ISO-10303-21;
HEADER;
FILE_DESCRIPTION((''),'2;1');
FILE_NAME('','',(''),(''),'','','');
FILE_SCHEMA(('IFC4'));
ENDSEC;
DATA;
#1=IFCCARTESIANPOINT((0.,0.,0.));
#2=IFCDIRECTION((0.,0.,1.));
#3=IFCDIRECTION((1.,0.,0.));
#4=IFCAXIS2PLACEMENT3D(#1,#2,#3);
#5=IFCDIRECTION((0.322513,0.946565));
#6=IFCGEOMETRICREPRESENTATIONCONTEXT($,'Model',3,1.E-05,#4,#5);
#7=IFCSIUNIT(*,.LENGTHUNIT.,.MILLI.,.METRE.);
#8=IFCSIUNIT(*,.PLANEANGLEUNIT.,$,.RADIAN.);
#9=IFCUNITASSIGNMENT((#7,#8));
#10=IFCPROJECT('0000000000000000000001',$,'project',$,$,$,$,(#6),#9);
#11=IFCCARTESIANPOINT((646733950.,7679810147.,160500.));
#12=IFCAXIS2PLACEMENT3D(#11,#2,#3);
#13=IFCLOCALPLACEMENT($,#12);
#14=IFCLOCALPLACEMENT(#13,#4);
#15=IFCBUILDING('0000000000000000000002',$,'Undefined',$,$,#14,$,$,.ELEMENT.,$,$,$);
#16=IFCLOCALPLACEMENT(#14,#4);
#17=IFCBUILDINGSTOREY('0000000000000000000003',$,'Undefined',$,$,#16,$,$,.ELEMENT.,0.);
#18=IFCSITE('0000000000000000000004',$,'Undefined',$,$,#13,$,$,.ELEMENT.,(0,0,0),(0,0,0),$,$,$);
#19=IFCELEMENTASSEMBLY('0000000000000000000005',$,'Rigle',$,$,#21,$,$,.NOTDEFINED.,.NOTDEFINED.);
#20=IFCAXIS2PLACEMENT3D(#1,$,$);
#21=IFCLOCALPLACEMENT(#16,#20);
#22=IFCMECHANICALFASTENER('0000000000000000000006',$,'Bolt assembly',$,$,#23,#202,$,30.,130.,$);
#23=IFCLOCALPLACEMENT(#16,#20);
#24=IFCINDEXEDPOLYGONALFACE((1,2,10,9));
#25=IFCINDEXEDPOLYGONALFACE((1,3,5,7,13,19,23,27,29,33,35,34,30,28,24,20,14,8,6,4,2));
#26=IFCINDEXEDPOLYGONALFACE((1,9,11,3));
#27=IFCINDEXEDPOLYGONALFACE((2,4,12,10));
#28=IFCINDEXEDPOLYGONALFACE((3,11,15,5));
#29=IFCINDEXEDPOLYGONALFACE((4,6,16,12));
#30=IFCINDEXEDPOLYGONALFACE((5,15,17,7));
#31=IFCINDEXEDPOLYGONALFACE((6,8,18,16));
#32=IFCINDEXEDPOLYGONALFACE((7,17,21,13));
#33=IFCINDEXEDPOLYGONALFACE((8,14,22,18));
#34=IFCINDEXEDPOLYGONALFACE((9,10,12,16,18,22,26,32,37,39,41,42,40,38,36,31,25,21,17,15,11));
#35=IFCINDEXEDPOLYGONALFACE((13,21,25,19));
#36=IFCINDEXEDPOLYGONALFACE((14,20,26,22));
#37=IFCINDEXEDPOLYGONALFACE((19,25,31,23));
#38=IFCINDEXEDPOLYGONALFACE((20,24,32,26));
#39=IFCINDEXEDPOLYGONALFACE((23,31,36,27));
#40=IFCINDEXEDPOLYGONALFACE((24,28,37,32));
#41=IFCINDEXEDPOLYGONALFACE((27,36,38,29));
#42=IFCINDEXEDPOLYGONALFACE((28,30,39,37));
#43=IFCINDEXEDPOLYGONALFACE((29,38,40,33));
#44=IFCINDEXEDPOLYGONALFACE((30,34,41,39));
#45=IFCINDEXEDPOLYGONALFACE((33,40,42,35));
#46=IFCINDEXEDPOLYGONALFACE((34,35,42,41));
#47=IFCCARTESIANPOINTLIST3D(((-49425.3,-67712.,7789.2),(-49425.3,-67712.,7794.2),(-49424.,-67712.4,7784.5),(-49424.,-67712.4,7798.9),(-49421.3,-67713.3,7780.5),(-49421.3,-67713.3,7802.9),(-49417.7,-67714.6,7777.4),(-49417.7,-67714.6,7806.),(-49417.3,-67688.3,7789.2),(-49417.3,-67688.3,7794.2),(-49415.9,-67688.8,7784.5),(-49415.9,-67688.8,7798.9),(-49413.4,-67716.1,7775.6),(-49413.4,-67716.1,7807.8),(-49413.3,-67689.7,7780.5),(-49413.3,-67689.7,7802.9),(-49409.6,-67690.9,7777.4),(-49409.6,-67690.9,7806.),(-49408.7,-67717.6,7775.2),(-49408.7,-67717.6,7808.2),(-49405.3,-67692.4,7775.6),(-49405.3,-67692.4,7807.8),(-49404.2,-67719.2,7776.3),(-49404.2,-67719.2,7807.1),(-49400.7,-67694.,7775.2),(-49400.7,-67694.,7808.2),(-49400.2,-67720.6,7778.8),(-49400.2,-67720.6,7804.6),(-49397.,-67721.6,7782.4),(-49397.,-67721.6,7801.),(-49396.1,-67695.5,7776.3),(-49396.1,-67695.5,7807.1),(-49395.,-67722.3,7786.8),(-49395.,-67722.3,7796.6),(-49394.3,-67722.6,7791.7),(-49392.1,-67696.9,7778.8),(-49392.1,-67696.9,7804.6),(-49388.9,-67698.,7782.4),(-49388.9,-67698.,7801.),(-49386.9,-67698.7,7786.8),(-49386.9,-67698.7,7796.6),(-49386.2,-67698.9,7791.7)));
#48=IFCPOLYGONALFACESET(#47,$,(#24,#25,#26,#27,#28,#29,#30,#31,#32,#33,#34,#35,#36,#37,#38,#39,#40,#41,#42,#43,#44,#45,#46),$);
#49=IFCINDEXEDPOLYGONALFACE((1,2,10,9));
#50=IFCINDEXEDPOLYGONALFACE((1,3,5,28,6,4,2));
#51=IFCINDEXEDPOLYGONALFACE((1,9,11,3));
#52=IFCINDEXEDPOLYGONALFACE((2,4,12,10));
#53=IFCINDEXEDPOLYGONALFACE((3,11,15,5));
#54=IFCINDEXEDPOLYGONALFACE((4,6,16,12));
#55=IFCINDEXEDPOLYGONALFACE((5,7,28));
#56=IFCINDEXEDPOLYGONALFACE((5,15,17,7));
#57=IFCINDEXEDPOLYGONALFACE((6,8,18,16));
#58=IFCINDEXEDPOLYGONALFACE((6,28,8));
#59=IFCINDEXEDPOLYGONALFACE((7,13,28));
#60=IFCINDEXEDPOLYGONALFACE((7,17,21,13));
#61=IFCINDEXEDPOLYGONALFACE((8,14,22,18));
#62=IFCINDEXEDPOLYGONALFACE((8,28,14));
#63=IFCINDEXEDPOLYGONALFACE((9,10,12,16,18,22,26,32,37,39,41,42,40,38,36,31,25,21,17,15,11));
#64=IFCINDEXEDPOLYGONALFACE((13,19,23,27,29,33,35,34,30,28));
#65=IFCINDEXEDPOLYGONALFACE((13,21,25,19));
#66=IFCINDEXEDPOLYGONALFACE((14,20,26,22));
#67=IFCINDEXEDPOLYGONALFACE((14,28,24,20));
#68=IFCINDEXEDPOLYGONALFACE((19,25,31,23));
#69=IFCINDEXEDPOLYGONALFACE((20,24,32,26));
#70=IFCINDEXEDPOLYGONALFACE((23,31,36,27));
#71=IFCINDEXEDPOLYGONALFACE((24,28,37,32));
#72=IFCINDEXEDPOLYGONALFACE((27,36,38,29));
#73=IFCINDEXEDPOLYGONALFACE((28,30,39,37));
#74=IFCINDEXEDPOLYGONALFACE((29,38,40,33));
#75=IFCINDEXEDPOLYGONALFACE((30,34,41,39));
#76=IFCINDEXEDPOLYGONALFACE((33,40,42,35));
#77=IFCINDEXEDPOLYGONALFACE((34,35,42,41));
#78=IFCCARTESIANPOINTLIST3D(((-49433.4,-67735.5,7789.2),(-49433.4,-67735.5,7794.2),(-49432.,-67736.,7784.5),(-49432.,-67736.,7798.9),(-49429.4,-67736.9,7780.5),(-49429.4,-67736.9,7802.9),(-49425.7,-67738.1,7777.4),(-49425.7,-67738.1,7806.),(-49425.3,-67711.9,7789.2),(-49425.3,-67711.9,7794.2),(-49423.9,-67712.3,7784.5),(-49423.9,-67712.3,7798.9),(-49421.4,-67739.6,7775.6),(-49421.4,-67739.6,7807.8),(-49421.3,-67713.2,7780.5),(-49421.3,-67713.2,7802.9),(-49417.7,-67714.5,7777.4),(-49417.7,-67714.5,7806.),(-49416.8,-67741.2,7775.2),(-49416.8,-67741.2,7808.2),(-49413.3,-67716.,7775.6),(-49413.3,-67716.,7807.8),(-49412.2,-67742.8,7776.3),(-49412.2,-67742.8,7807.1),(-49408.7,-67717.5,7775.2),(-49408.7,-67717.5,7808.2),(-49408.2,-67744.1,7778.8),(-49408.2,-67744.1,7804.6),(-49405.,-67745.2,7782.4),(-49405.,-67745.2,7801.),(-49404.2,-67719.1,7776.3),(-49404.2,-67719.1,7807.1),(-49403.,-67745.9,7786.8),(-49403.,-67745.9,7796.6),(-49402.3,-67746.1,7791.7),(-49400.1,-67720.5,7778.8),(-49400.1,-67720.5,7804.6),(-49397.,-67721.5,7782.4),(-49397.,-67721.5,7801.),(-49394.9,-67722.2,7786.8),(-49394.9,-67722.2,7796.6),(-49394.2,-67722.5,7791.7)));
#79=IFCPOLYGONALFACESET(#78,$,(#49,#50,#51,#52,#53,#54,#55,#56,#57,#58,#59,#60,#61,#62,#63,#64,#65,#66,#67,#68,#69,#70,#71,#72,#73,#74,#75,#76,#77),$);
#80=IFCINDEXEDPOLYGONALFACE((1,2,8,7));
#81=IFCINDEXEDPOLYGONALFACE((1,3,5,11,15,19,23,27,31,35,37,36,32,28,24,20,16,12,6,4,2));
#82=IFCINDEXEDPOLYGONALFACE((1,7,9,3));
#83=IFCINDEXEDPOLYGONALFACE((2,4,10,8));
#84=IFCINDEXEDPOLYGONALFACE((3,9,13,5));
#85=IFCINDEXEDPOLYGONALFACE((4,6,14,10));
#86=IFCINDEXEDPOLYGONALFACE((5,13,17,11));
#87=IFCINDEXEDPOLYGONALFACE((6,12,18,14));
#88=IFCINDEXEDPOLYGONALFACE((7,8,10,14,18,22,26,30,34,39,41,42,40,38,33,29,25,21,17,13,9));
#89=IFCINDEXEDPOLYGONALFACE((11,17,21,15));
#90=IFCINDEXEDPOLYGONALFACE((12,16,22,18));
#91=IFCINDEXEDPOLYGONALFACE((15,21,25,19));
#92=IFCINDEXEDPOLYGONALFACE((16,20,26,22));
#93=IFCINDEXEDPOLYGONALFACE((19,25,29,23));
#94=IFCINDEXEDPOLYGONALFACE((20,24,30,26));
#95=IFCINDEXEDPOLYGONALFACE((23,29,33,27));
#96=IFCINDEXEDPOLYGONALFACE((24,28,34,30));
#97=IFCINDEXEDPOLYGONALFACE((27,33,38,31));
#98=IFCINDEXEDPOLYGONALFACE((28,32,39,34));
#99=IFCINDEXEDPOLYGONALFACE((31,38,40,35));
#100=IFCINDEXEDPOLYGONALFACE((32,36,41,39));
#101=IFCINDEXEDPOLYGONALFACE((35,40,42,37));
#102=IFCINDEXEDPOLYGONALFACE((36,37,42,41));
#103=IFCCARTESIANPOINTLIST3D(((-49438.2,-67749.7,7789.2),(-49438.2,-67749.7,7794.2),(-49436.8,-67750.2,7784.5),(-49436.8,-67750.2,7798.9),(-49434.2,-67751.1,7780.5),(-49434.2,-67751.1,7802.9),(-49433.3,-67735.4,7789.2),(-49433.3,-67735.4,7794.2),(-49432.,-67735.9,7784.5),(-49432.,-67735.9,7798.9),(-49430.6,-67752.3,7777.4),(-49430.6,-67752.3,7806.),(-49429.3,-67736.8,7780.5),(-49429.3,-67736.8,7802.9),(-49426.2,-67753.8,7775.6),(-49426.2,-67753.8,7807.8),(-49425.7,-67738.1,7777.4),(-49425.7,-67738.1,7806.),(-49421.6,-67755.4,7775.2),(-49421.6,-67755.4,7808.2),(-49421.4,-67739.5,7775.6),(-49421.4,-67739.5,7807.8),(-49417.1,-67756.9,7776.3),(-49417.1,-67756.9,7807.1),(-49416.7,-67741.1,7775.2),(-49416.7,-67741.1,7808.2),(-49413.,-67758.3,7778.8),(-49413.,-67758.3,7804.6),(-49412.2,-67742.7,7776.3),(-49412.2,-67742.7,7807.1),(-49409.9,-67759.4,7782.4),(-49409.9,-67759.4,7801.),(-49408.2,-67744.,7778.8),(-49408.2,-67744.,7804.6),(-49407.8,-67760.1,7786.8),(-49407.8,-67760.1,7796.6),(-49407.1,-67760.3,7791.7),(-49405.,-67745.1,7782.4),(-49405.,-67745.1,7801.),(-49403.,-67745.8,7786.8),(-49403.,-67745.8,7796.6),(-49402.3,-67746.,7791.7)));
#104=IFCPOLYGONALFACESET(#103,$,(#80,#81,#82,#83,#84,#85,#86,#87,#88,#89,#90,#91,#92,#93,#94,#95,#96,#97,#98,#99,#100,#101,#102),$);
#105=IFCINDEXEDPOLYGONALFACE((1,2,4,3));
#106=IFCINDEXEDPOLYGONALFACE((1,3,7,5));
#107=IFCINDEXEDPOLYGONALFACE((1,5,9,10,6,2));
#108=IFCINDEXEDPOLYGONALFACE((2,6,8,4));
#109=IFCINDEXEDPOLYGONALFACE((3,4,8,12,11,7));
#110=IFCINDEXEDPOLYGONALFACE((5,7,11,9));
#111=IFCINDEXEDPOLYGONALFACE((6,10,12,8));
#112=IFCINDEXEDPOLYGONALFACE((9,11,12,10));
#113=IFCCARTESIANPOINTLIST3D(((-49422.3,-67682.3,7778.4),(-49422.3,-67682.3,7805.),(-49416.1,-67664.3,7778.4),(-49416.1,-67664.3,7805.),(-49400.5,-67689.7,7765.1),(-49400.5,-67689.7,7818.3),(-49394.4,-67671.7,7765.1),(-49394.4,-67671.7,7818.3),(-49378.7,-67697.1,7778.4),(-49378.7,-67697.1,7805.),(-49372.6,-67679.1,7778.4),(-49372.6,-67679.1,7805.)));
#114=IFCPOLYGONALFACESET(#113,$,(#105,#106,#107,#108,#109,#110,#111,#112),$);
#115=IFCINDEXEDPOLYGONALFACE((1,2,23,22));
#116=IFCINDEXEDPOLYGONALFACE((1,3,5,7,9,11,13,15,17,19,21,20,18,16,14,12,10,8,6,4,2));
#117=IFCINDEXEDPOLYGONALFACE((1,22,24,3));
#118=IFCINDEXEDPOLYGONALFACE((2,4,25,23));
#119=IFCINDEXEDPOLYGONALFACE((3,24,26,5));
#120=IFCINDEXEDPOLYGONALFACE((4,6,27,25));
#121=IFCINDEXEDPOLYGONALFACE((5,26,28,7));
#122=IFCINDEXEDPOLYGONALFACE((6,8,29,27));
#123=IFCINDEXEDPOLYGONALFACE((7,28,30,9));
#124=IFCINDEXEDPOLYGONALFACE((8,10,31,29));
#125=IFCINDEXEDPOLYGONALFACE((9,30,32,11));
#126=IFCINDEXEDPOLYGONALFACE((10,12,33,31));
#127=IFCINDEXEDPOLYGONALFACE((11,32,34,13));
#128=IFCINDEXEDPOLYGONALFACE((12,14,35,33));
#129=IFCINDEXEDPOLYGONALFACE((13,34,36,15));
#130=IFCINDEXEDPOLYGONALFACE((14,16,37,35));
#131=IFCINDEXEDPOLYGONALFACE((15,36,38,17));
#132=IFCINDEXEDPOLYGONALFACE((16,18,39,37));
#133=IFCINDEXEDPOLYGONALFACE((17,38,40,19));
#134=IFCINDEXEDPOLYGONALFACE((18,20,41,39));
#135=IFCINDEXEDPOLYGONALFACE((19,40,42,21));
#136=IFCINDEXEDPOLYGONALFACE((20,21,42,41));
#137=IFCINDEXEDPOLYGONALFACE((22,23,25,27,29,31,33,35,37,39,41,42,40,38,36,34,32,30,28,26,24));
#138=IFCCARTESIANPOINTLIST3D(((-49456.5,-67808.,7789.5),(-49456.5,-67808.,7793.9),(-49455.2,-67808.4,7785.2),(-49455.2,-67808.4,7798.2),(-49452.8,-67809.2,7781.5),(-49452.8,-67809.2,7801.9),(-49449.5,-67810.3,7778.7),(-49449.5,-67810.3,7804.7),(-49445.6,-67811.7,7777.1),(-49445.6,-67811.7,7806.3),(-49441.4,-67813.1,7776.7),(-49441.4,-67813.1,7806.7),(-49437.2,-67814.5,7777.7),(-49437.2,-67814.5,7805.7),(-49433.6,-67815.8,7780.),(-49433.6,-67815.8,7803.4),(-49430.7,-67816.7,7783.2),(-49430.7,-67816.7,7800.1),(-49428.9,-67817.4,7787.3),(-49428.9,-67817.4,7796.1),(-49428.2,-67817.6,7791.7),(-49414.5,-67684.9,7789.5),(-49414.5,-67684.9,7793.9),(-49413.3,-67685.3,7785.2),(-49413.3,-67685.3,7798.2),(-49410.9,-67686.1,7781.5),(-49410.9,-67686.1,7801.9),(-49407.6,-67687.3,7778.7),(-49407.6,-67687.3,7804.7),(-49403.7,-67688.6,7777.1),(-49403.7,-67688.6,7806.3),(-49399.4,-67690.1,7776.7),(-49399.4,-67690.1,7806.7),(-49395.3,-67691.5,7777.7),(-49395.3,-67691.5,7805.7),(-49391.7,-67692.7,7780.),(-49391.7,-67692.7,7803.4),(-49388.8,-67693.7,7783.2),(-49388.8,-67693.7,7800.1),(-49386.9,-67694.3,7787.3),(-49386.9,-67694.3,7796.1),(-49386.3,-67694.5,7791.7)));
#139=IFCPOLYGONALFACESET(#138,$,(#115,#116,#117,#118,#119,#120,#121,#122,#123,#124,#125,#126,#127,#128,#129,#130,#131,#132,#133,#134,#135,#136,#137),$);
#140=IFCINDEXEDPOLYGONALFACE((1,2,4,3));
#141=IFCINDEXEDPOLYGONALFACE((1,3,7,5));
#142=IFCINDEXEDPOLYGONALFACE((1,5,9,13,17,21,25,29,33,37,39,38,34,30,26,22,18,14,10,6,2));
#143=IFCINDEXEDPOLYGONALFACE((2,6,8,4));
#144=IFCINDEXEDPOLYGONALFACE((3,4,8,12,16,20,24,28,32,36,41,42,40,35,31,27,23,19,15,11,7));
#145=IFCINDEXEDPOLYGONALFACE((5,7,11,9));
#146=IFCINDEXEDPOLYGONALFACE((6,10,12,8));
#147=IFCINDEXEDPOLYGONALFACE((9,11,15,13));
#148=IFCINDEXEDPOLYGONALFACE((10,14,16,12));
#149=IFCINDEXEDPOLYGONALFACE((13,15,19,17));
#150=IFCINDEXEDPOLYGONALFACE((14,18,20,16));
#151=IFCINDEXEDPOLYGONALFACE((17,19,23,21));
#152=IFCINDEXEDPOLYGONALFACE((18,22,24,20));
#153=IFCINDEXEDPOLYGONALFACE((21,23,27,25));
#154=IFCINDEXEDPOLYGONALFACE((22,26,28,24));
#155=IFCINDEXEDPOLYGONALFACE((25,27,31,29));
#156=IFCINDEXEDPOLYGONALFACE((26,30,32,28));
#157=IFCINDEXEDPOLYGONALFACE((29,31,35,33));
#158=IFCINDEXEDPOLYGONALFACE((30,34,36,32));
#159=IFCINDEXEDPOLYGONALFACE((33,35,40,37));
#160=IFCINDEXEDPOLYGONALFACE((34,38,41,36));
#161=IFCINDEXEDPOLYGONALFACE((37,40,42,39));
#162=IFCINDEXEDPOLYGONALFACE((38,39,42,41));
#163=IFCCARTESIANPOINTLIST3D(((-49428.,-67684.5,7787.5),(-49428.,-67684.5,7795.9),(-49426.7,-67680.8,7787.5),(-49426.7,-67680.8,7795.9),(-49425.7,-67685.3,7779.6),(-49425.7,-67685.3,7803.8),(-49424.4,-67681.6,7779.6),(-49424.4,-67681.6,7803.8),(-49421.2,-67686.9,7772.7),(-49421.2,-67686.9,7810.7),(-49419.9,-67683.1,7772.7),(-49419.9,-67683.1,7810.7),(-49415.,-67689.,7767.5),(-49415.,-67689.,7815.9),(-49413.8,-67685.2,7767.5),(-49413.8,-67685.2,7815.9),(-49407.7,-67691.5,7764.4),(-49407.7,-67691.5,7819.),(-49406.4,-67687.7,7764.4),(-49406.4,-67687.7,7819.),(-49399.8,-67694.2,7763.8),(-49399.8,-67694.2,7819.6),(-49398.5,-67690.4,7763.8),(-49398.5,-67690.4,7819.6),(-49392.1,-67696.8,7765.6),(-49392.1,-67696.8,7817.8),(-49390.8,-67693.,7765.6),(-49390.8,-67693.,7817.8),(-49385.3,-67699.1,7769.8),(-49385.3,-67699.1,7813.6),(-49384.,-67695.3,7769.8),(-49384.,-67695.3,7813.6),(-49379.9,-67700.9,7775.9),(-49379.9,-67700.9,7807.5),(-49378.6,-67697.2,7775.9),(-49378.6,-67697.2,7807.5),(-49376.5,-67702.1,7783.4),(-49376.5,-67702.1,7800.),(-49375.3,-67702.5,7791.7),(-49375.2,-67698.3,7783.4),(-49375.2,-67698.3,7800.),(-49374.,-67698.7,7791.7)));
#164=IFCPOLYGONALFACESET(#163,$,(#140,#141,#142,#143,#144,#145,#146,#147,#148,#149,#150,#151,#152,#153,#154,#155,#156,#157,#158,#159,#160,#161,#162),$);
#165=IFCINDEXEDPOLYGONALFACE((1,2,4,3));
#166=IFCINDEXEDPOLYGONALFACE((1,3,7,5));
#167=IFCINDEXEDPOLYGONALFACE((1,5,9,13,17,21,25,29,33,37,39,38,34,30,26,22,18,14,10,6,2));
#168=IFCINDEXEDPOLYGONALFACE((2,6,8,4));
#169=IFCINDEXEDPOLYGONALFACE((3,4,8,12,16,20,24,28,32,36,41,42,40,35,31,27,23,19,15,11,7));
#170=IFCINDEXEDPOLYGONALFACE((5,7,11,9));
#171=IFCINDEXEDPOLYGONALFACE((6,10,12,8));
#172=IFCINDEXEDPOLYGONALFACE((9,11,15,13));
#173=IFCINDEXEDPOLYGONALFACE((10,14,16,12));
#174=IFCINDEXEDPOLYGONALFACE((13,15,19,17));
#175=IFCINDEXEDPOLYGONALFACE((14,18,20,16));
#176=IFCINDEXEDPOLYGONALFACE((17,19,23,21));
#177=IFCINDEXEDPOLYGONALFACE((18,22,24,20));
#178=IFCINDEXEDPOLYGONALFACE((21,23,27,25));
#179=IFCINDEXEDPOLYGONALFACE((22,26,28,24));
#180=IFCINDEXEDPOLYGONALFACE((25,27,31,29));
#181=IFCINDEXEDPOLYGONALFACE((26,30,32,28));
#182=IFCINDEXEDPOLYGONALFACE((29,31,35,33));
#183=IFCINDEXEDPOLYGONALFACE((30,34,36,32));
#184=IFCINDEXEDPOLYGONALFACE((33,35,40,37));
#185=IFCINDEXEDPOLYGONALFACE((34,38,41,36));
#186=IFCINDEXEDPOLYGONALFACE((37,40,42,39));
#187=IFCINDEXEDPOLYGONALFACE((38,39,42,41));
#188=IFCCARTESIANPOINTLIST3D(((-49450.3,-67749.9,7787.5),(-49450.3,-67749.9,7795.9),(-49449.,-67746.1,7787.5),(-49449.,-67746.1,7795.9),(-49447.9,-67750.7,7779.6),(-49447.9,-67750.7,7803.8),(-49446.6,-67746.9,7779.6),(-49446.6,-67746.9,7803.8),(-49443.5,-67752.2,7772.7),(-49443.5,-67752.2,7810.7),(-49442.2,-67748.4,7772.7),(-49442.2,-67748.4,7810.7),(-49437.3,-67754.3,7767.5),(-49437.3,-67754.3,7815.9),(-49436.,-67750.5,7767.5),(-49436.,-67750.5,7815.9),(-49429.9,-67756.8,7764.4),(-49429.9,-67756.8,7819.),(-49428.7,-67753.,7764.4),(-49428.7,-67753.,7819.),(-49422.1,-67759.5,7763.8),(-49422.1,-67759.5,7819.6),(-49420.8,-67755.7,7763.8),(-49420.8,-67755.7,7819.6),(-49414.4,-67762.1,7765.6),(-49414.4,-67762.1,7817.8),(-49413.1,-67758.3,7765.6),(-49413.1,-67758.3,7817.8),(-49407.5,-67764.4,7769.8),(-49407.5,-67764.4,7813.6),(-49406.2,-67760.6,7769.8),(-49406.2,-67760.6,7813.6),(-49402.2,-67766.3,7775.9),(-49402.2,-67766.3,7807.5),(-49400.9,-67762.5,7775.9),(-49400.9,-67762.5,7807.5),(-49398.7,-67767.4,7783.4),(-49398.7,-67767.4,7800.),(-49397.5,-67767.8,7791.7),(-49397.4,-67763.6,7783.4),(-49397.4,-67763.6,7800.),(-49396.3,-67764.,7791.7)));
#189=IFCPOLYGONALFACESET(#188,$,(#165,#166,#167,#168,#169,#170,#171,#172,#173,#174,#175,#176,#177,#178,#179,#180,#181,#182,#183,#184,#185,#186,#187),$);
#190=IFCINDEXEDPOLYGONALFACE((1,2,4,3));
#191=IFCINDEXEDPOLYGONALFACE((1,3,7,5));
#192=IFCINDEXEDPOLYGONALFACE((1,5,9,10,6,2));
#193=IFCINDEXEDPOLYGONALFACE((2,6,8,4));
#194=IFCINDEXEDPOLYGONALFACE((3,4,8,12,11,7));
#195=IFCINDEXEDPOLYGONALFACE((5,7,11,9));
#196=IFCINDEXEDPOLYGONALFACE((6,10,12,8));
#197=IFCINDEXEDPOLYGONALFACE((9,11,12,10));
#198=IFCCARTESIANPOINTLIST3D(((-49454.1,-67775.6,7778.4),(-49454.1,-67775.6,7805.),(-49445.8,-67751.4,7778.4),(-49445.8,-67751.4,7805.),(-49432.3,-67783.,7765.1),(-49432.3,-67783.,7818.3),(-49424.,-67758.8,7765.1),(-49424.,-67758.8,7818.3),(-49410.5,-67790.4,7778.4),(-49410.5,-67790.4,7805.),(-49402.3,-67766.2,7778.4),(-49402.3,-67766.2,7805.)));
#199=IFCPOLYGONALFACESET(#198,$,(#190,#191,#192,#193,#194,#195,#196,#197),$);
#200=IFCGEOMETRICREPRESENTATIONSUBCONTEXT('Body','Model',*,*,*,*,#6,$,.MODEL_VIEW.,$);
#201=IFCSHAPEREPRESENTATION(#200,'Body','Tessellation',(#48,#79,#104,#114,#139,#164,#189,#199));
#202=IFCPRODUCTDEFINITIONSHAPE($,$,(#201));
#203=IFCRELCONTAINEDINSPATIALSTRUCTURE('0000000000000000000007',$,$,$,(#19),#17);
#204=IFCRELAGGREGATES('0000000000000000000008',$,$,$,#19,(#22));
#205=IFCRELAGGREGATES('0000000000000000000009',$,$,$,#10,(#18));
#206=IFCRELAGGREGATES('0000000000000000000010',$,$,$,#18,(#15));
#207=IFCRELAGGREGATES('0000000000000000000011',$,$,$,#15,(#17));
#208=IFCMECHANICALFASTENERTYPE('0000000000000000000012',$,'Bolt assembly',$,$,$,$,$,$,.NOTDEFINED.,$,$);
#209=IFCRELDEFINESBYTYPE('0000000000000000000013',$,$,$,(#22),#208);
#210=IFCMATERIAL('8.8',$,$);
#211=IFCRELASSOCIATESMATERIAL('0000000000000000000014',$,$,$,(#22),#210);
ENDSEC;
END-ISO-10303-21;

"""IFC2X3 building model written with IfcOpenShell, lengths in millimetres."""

from ifc_helpers import new_model, si_unit, direction, frame, origin_with_axes, origin_2d_with_axis, place, context, subcontext, project, spatial, polyline, circle, outline, extrude, source, transform, mapped, material, type_object, element, aggregate, save


model = new_model("IFC2X3")

# Units and contexts
model_context = context("Model", 3, precision=1e-05, world=origin_with_axes(), true_north=direction((0.322513, 0.946565)))
body_context = subcontext(model_context, "Body", "Model", "MODEL_VIEW")
ifc_project = project(units=[si_unit("LENGTHUNIT", "METRE", prefix="MILLI"), si_unit("PLANEANGLEUNIT", "RADIAN")], contexts=[model_context])

# Site, building, storey
site_placement = place(None, frame((646733950.0, 7679810147.0, 160500.0), z_axis=(0.0, 0.0, 1.0), x_axis=(1.0, 0.0, 0.0)))
site = spatial("IfcSite", under=ifc_project, at=site_placement, Name="Undefined", CompositionType="ELEMENT", RefLatitude=(0, 0, 0), RefLongitude=(0, 0, 0))
building_placement = place(site_placement, origin_with_axes())
building = spatial("IfcBuilding", under=site, at=building_placement, Name="Undefined", CompositionType="ELEMENT")
storey_placement = place(building_placement, origin_with_axes())
storey = spatial("IfcBuildingStorey", under=building, at=storey_placement, Name="Undefined", CompositionType="ELEMENT", Elevation=0.0)

# Element assembly
assembly_1_placement = place(storey_placement, origin_with_axes())
assembly_1 = element("IfcElementAssembly", 1, at=assembly_1_placement, inside=storey, Name="Rigle", AssemblyPlace="NOTDEFINED", PredefinedType="NOTDEFINED")

# Mechanical fastener
ifc_material_1 = material(Name="8.8")
mechanical_fastener_type = type_object("IfcMechanicalFastenerType", Name="Bolt assembly")
shared_shape_1 = source(origin_with_axes(), body_context, "Body", "SweptSolid", [
    extrude(circle(Radius=16.5, at=origin_2d_with_axis()), frame((0.0, -57.4, 0.0), z_axis=(0.0, 1.0, 0.0), x_axis=(1.0, 0.0, 0.0)), (0.0, 0.0, 1.0), 25.0),
    extrude(circle(Radius=16.5, at=origin_2d_with_axis()), frame((0.0, -32.5, 0.0), z_axis=(0.0, 1.0, 0.0), x_axis=(1.0, 0.0, 0.0)), (0.0, 0.0, 1.0), 25.0),
    extrude(circle(Radius=16.5, at=origin_2d_with_axis()), frame((0.0, -7.6, 0.0), z_axis=(0.0, 1.0, 0.0), x_axis=(1.0, 0.0, 0.0)), (0.0, 0.0, 1.0), 15.1),
    extrude(outline(polyline([(23.0, -13.3), (23.0, 13.3), (0.0, 26.6), (-23.0, 13.3), (-23.0, -13.3), (0.0, -26.6), (23.0, -13.3)])), frame((0.0, -80.5, 0.0), z_axis=(0.0, 1.0, 0.0), x_axis=(1.0, 0.0, 0.0)), (0.0, 0.0, 1.0), 19.0),
    extrude(circle(Radius=15.0, at=origin_2d_with_axis()), frame((0.0, -61.5, 0.0), z_axis=(0.0, 1.0, 0.0), x_axis=(1.0, 0.0, 0.0)), (0.0, 0.0, 1.0), 130.0),
    extrude(circle(Radius=28.0, at=origin_2d_with_axis()), frame((0.0, -61.5, 0.0), z_axis=(0.0, 1.0, 0.0), x_axis=(1.0, 0.0, 0.0)), (0.0, 0.0, 1.0), 4.0),
    extrude(circle(Radius=28.0, at=origin_2d_with_axis()), frame((0.0, 7.5, 0.0), z_axis=(0.0, 1.0, 0.0), x_axis=(1.0, 0.0, 0.0)), (0.0, 0.0, 1.0), 4.0),
    extrude(outline(polyline([(23.0, -13.3), (23.0, 13.3), (0.0, 26.6), (-23.0, 13.3), (-23.0, -13.3), (0.0, -26.6), (23.0, -13.3)])), frame((0.0, 11.5, 0.0), z_axis=(0.0, 1.0, 0.0), x_axis=(1.0, 0.0, 0.0)), (0.0, 0.0, 1.0), 25.6),
])
mechanical_fastener_1_placement = place(assembly_1_placement, frame((-49420.3, -67747.9, 7791.7), z_axis=(0.0, 0.0, -1.0), x_axis=(0.946565, -0.322513, 0.0)))
mechanical_fastener_1 = element("IfcMechanicalFastener", 2, at=mechanical_fastener_1_placement, type_object=mechanical_fastener_type, material=ifc_material_1, Name="Bolt assembly", NominalDiameter=30.0, NominalLength=130.0, context=body_context, shape_type="MappedRepresentation", body=[
    mapped(shared_shape_1, transform((0.0, 0.0, 0.0))),
])
aggregate(assembly_1, [mechanical_fastener_1])

save(model, "model.ifc")
